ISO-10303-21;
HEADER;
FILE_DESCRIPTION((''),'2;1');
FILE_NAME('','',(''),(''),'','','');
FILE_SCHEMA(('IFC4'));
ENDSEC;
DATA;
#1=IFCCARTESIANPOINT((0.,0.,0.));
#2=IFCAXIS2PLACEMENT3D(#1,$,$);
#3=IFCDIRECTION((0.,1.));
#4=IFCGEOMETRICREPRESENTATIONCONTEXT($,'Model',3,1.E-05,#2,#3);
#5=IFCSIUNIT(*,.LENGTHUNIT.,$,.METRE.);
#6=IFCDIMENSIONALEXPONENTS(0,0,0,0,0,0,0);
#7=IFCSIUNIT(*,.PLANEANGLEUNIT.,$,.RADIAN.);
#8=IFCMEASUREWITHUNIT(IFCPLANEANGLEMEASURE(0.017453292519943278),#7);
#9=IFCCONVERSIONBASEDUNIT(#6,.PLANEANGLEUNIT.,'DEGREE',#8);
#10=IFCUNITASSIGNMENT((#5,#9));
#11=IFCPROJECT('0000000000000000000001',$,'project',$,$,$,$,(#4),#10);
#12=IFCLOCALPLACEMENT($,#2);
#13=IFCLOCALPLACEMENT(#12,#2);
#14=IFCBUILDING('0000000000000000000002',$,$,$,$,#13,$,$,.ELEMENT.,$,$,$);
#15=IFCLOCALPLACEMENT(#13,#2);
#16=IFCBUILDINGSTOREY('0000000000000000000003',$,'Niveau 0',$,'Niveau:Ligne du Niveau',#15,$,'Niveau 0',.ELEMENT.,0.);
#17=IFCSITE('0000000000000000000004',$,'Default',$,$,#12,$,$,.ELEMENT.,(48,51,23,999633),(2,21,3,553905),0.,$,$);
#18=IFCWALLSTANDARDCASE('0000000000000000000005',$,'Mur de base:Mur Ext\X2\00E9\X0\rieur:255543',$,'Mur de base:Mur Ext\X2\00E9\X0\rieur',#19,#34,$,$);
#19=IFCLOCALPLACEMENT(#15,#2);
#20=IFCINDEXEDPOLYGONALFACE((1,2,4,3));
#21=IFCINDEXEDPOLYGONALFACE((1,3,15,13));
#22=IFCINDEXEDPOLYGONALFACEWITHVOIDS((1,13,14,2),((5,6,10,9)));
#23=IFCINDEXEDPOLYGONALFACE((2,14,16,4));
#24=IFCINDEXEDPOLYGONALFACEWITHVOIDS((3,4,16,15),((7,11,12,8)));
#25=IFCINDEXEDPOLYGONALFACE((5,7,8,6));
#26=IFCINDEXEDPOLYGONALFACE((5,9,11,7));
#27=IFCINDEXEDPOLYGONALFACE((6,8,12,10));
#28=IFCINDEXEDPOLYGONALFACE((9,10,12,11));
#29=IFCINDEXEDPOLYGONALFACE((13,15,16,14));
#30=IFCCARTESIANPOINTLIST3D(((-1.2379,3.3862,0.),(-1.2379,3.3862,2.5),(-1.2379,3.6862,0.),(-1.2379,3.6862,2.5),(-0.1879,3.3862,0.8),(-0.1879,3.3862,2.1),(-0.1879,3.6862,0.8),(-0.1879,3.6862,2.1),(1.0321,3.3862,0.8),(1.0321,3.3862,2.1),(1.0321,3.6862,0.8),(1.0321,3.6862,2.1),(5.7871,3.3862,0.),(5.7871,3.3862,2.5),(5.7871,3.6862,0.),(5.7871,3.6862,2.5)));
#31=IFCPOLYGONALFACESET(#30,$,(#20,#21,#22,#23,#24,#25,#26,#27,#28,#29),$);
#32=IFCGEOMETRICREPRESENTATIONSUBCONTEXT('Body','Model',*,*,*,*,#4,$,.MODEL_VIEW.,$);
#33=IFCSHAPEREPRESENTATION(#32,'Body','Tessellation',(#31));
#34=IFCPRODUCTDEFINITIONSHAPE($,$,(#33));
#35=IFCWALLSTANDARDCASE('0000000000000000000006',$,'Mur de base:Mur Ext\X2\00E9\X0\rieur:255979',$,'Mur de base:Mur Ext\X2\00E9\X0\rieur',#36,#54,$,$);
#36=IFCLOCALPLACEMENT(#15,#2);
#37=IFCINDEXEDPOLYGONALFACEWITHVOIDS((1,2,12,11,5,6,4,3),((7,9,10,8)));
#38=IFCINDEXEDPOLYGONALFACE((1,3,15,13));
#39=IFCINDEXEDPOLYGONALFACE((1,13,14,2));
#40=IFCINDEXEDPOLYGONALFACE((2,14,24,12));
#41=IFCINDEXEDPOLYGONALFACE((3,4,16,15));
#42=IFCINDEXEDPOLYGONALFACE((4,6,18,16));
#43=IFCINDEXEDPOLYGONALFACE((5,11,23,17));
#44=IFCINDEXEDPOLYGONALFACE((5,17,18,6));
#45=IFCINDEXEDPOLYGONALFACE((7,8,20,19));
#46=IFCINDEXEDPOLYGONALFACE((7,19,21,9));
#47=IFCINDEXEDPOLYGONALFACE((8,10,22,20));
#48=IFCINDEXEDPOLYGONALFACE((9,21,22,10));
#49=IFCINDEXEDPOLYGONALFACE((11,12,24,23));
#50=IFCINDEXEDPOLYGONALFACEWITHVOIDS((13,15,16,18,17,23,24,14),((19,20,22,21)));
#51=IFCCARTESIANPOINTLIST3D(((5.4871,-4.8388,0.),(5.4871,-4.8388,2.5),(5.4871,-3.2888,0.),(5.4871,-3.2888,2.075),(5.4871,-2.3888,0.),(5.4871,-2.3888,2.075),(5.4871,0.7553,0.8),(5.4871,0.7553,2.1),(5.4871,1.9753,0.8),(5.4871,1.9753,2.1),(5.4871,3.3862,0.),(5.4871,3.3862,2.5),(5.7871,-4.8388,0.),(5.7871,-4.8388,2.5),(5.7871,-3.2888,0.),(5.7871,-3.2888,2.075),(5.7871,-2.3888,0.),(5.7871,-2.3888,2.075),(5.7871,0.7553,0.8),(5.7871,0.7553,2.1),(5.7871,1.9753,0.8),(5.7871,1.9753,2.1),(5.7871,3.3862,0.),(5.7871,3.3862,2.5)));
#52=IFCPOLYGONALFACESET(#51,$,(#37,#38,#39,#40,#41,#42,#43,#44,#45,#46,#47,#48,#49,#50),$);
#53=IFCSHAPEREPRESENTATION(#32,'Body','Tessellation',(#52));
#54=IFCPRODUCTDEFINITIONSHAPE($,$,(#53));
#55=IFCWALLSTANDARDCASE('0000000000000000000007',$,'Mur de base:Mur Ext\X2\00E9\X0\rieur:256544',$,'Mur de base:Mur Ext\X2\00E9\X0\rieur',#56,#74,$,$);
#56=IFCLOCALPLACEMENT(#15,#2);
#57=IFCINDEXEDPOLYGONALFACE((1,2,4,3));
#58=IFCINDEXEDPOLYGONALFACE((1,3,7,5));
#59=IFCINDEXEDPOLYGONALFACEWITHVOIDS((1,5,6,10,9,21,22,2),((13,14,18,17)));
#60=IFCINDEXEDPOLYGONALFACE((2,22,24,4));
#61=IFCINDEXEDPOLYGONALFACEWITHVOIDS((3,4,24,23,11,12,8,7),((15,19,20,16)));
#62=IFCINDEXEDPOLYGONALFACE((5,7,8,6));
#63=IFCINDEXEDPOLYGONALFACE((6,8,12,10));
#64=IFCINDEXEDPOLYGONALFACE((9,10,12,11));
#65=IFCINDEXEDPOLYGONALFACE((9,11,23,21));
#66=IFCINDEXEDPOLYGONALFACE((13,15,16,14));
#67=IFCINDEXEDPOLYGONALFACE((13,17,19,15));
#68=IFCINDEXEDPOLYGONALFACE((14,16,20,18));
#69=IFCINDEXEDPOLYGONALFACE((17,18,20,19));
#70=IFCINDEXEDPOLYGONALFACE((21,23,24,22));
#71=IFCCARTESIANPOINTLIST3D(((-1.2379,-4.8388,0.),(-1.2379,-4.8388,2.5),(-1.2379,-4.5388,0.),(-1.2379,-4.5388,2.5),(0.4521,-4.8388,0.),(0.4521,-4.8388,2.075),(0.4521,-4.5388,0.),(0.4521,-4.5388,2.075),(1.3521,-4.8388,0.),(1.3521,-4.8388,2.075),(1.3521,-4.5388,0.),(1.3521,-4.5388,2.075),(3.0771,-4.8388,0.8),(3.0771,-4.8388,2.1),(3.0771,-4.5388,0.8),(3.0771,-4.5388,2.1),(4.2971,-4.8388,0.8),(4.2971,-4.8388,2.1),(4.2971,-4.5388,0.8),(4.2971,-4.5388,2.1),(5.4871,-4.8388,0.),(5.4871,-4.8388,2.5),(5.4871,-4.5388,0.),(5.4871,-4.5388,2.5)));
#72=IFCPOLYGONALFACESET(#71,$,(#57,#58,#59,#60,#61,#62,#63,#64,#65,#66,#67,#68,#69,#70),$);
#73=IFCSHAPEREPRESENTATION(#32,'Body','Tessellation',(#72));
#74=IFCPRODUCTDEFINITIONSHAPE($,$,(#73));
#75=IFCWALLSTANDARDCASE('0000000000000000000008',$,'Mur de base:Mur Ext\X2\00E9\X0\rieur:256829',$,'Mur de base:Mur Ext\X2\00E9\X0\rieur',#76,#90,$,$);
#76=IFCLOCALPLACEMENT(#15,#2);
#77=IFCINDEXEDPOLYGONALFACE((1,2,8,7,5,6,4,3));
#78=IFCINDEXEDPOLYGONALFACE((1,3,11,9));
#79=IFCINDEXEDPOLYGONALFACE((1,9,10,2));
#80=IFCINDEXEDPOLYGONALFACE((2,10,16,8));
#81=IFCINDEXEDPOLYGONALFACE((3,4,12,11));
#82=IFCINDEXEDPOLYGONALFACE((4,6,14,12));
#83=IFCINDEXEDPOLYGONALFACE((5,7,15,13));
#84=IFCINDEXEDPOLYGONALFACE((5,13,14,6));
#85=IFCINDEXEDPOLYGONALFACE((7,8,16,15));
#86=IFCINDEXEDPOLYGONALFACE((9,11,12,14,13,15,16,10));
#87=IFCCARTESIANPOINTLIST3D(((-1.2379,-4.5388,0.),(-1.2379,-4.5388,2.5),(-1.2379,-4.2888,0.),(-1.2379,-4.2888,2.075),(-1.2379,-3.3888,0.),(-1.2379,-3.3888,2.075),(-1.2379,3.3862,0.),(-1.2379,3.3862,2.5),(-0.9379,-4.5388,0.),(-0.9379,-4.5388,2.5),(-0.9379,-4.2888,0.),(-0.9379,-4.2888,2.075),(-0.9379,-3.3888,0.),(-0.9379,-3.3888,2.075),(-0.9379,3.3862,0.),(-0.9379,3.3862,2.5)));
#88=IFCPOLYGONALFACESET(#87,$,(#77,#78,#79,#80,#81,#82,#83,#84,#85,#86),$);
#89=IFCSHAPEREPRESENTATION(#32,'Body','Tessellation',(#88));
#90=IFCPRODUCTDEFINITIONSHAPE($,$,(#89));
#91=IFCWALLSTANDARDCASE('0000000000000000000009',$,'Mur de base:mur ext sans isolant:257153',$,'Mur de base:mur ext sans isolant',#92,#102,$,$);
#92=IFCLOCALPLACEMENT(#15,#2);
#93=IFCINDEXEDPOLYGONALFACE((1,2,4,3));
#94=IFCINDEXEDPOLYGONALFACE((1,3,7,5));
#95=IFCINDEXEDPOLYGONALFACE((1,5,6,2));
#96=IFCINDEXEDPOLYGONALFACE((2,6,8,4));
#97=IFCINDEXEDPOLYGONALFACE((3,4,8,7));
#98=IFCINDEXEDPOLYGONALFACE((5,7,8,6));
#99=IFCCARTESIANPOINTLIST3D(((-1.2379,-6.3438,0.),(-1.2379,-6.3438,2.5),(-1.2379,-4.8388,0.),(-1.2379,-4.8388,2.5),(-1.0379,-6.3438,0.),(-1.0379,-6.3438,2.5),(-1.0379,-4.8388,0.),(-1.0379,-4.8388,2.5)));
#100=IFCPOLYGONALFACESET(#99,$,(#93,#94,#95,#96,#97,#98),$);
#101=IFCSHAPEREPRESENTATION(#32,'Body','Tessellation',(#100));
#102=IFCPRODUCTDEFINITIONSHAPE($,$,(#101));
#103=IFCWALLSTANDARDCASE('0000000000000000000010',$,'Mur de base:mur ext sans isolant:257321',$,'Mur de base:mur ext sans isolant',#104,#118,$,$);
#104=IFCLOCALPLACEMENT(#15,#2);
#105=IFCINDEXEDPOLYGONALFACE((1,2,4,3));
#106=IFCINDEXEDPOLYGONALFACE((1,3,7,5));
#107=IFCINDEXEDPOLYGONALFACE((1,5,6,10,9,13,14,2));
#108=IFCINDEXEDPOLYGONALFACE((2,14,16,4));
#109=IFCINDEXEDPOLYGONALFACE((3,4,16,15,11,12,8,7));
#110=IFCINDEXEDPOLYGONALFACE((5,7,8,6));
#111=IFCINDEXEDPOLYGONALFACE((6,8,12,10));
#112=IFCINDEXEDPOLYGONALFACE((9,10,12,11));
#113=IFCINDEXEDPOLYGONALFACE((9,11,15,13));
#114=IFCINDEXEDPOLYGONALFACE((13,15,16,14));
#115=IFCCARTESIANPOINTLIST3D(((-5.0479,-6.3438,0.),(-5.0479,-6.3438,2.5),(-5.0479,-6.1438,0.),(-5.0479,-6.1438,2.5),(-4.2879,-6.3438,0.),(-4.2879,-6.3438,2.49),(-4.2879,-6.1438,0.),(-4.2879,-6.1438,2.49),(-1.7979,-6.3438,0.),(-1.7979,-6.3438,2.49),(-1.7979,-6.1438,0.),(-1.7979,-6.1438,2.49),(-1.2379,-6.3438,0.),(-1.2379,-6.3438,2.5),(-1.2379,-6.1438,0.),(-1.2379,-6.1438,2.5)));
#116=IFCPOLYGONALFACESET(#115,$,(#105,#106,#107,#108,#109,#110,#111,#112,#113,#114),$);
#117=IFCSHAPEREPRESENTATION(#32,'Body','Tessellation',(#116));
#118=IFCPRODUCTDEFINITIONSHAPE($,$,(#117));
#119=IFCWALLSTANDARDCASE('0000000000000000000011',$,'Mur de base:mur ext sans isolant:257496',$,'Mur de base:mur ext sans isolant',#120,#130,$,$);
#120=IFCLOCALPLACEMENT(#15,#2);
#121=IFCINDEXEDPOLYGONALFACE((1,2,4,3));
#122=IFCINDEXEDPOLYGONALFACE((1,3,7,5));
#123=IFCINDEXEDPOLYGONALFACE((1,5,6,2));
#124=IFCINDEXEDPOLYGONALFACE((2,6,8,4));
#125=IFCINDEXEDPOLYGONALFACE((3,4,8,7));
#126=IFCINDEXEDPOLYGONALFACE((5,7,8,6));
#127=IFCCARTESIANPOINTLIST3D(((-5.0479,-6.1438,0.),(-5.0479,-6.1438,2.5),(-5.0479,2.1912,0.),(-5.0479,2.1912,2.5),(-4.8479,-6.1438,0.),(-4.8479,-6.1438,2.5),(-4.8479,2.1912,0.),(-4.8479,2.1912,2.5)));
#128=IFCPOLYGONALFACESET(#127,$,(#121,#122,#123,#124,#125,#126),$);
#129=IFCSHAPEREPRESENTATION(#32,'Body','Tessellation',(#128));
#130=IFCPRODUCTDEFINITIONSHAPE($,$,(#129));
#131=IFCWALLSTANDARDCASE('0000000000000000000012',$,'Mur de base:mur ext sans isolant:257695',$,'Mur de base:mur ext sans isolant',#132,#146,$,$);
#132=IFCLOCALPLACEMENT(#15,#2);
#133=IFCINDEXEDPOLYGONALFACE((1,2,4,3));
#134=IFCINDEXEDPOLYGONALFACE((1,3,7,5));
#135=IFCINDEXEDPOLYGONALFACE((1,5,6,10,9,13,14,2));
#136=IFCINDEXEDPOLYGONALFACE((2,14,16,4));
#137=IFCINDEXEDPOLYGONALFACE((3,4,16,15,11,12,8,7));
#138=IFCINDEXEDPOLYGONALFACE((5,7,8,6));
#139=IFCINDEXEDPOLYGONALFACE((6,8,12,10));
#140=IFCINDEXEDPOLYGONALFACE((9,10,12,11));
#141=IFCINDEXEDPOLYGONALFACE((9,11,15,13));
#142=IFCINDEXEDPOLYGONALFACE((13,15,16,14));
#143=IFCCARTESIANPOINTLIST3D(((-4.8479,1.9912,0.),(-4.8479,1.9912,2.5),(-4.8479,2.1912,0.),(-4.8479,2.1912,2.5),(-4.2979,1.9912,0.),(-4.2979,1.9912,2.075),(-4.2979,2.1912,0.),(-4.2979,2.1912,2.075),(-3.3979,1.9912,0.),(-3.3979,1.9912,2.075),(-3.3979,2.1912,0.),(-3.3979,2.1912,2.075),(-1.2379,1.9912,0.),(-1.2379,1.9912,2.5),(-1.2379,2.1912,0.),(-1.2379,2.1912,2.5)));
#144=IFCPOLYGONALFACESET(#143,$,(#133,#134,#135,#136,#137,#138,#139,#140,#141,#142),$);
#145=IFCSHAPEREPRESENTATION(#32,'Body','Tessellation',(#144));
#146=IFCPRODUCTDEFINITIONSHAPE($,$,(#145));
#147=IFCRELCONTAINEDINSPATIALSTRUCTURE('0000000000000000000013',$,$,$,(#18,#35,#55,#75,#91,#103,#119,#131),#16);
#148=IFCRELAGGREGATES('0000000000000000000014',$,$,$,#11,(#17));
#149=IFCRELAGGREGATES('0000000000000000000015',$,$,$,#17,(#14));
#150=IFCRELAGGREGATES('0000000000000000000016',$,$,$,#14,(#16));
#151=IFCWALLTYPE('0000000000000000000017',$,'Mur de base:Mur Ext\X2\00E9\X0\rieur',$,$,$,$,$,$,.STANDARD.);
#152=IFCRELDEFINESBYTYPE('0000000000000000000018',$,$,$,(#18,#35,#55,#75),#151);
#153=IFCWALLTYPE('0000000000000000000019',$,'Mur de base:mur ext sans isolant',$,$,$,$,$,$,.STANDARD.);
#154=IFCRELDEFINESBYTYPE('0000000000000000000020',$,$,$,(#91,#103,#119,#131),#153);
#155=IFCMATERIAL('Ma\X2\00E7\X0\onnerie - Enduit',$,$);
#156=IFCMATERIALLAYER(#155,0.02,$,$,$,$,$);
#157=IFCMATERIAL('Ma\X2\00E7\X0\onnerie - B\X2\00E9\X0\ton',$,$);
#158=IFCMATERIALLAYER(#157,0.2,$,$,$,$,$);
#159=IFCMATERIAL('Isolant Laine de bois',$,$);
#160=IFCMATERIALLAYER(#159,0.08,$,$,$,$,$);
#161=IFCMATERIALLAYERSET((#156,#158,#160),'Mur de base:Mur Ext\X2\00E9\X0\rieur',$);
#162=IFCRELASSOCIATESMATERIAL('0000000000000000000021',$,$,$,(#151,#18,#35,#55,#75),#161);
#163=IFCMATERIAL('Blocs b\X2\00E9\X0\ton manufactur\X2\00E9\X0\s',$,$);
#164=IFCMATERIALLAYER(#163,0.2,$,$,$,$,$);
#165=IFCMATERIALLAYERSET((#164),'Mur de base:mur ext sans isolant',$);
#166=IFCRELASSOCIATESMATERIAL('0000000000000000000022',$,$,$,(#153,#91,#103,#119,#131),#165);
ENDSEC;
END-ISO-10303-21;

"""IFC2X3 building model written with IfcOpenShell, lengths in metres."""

from ifc_helpers import new_model, entity, si_unit, converted_unit, direction, frame, frame_2d, origin, place, context, subcontext, project, spatial, rectangle, extrude, material, layer, layer_set, layer_usage, type_object, element, save


model = new_model("IFC2X3")

# Units and contexts
model_context = context("Model", 3, precision=1e-05, world=origin(), true_north=direction((0.0, 1.0)))
body_context = subcontext(model_context, "Body", "Model", "MODEL_VIEW")
ifc_project = project(units=[si_unit("LENGTHUNIT", "METRE"), converted_unit("PLANEANGLEUNIT", "DEGREE", entity("IfcPlaneAngleMeasure", 0.017453292519943278), si_unit("PLANEANGLEUNIT", "RADIAN"), dimensions=[0, 0, 0, 0, 0, 0, 0])], contexts=[model_context])

# Site, building, storey
site_placement = place(None, origin())
site = spatial("IfcSite", under=ifc_project, at=site_placement, Name="Default", CompositionType="ELEMENT", RefLatitude=(48, 51, 23, 999633), RefLongitude=(2, 21, 3, 553905), RefElevation=0.0)
building_placement = place(site_placement, origin())
building = spatial("IfcBuilding", under=site, at=building_placement, CompositionType="ELEMENT")
storey_placement = place(building_placement, origin())
storey = spatial("IfcBuildingStorey", under=building, at=storey_placement, Name="Niveau 0", ObjectType="Niveau:Ligne du Niveau", LongName="Niveau 0", CompositionType="ELEMENT", Elevation=0.0)

# Wall, opening
ifc_material_1 = material(Name="Maçonnerie - Enduit")
ifc_layer_1 = layer(ifc_material_1, 0.02)
ifc_material_2 = material(Name="Maçonnerie - Béton")
ifc_layer_2 = layer(ifc_material_2, 0.2)
ifc_material_3 = material(Name="Isolant Laine de bois")
ifc_layer_3 = layer(ifc_material_3, 0.08)
ifc_layer_set_1 = layer_set([ifc_layer_1, ifc_layer_2, ifc_layer_3], Name="Mur de base:Mur Extérieur")
ifc_layer_usage_1 = layer_usage(ifc_layer_set_1, "AXIS2", "NEGATIVE", 0.15)
wall_type_1 = type_object("IfcWallType", Name="Mur de base:Mur Extérieur", PredefinedType="STANDARD", material=ifc_layer_set_1)
wall_1_placement = place(storey_placement, frame((-1.2379, 3.5362, 0.0)))
wall_1 = element("IfcWallStandardCase", 1, at=wall_1_placement, inside=storey, type_object=wall_type_1, material=ifc_layer_usage_1, Name="Mur de base:Mur Extérieur:255543", ObjectType="Mur de base:Mur Extérieur", context=body_context, shape_type="SweptSolid", body=[
    extrude(rectangle(XDim=7.025, YDim=0.3, at=frame_2d((3.5125, 0.0), x_axis=(-1.0, 0.0))), origin(), (0.0, 0.0, 1.0), 2.5),
])
opening_1_placement = place(wall_1_placement, frame((1.05, -0.15, 0.8)))
element("IfcOpeningElement", 2, at=opening_1_placement, cuts=wall_1, ObjectType="Opening", context=body_context, shape_type="SweptSolid", body=[
    extrude(rectangle(XDim=1.3, YDim=1.22, at=frame_2d((0.65, 0.61), x_axis=(1.0, 0.0))), frame((0.0, 0.0, 0.0), z_axis=(0.0, 1.0, 0.0), x_axis=(0.0, 0.0, 1.0)), (0.0, 0.0, 1.0), 0.3),
])

# Walls, openings
ifc_layer_usage_2 = layer_usage(ifc_layer_set_1, "AXIS2", "NEGATIVE", 0.15)
wall_2_placement = place(storey_placement, frame((5.6371, 3.3862, 0.0), z_axis=(0.0, 0.0, 1.0), x_axis=(0.0, -1.0, 0.0)))
wall_2 = element("IfcWallStandardCase", 3, at=wall_2_placement, inside=storey, type_object=wall_type_1, material=ifc_layer_usage_2, Name="Mur de base:Mur Extérieur:255979", ObjectType="Mur de base:Mur Extérieur", context=body_context, shape_type="SweptSolid", body=[
    extrude(rectangle(XDim=8.225, YDim=0.3, at=frame_2d((4.1125, 0.0), x_axis=(-1.0, 0.0))), origin(), (0.0, 0.0, 1.0), 2.5),
])
opening_2_placement = place(wall_2_placement, frame((5.775, -0.15, 0.0)))
element("IfcOpeningElement", 4, at=opening_2_placement, cuts=wall_2, ObjectType="Opening", context=body_context, shape_type="SweptSolid", body=[
    extrude(rectangle(XDim=2.075, YDim=0.9, at=frame_2d((1.0375, 0.45), x_axis=(1.0, 0.0))), frame((0.0, 0.0, 0.0), z_axis=(0.0, 1.0, 0.0), x_axis=(0.0, 0.0, 1.0)), (0.0, 0.0, 1.0), 0.3),
])
opening_3_placement = place(wall_2_placement, frame((1.4109, -0.15, 0.8)))
element("IfcOpeningElement", 5, at=opening_3_placement, cuts=wall_2, ObjectType="Opening", context=body_context, shape_type="SweptSolid", body=[
    extrude(rectangle(XDim=1.3, YDim=1.22, at=frame_2d((0.65, 0.61), x_axis=(1.0, 0.0))), frame((0.0, 0.0, 0.0), z_axis=(0.0, 1.0, 0.0), x_axis=(0.0, 0.0, 1.0)), (0.0, 0.0, 1.0), 0.3),
])
ifc_layer_usage_3 = layer_usage(ifc_layer_set_1, "AXIS2", "NEGATIVE", 0.15)
wall_3_placement = place(storey_placement, frame((5.4871, -4.6888, 0.0), z_axis=(0.0, 0.0, 1.0), x_axis=(-1.0, 0.0, 0.0)))
wall_3 = element("IfcWallStandardCase", 6, at=wall_3_placement, inside=storey, type_object=wall_type_1, material=ifc_layer_usage_3, Name="Mur de base:Mur Extérieur:256544", ObjectType="Mur de base:Mur Extérieur", context=body_context, shape_type="SweptSolid", body=[
    extrude(rectangle(XDim=6.725, YDim=0.3, at=frame_2d((3.3625, 0.0), x_axis=(-1.0, 0.0))), origin(), (0.0, 0.0, 1.0), 2.5),
])
opening_4_placement = place(wall_3_placement, frame((5.035, 0.15, 0.0)))
element("IfcOpeningElement", 7, at=opening_4_placement, cuts=wall_3, ObjectType="Opening", context=body_context, shape_type="SweptSolid", body=[
    extrude(rectangle(XDim=2.075, YDim=0.9, at=frame_2d((1.0375, 0.45), x_axis=(1.0, 0.0))), frame((0.0, 0.0, 0.0), z_axis=(0.0, -1.0, 0.0), x_axis=(0.0, 0.0, 1.0)), (0.0, 0.0, 1.0), 0.3),
])
opening_5_placement = place(wall_3_placement, frame((1.19, -0.15, 0.8)))
element("IfcOpeningElement", 8, at=opening_5_placement, cuts=wall_3, ObjectType="Opening", context=body_context, shape_type="SweptSolid", body=[
    extrude(rectangle(XDim=1.3, YDim=1.22, at=frame_2d((0.65, 0.61), x_axis=(1.0, 0.0))), frame((0.0, 0.0, 0.0), z_axis=(0.0, 1.0, 0.0), x_axis=(0.0, 0.0, 1.0)), (0.0, 0.0, 1.0), 0.3),
])

# Wall, opening
ifc_layer_usage_4 = layer_usage(ifc_layer_set_1, "AXIS2", "POSITIVE", -0.15)
wall_4_placement = place(storey_placement, frame((-1.0879, 3.3862, 0.0), z_axis=(0.0, 0.0, 1.0), x_axis=(0.0, -1.0, 0.0)))
wall_4 = element("IfcWallStandardCase", 9, at=wall_4_placement, inside=storey, type_object=wall_type_1, material=ifc_layer_usage_4, Name="Mur de base:Mur Extérieur:256829", ObjectType="Mur de base:Mur Extérieur", context=body_context, shape_type="SweptSolid", body=[
    extrude(rectangle(XDim=7.925, YDim=0.3, at=frame_2d((3.9625, 0.0), x_axis=(1.0, 0.0))), origin(), (0.0, 0.0, 1.0), 2.5),
])
opening_6_placement = place(wall_4_placement, frame((6.775, -0.15, 0.0)))
element("IfcOpeningElement", 10, at=opening_6_placement, cuts=wall_4, ObjectType="Opening", context=body_context, shape_type="SweptSolid", body=[
    extrude(rectangle(XDim=2.075, YDim=0.9, at=frame_2d((1.0375, 0.45), x_axis=(1.0, 0.0))), frame((0.0, 0.0, 0.0), z_axis=(0.0, 1.0, 0.0), x_axis=(0.0, 0.0, 1.0)), (0.0, 0.0, 1.0), 0.3),
])

# Wall
ifc_material_4 = material(Name="Blocs béton manufacturés")
ifc_layer_4 = layer(ifc_material_4, 0.2)
ifc_layer_set_2 = layer_set([ifc_layer_4], Name="Mur de base:mur ext sans isolant")
ifc_layer_usage_5 = layer_usage(ifc_layer_set_2, "AXIS2", "POSITIVE", -0.1)
wall_type_2 = type_object("IfcWallType", Name="Mur de base:mur ext sans isolant", PredefinedType="STANDARD", material=ifc_layer_set_2)
wall_5_placement = place(storey_placement, frame((-1.1379, -4.8388, 0.0), z_axis=(0.0, 0.0, 1.0), x_axis=(0.0, -1.0, 0.0)))
element("IfcWallStandardCase", 11, at=wall_5_placement, inside=storey, type_object=wall_type_2, material=ifc_layer_usage_5, Name="Mur de base:mur ext sans isolant:257153", ObjectType="Mur de base:mur ext sans isolant", context=body_context, shape_type="SweptSolid", body=[
    extrude(rectangle(XDim=1.505, YDim=0.2, at=frame_2d((0.7525, 0.0), x_axis=(-1.0, 0.0))), origin(), (0.0, 0.0, 1.0), 2.5),
])

# Wall, opening
ifc_layer_usage_6 = layer_usage(ifc_layer_set_2, "AXIS2", "NEGATIVE", 0.1)
wall_6_placement = place(storey_placement, frame((-1.2379, -6.2438, 0.0), z_axis=(0.0, 0.0, 1.0), x_axis=(-1.0, 0.0, 0.0)))
wall_6 = element("IfcWallStandardCase", 12, at=wall_6_placement, inside=storey, type_object=wall_type_2, material=ifc_layer_usage_6, Name="Mur de base:mur ext sans isolant:257321", ObjectType="Mur de base:mur ext sans isolant", context=body_context, shape_type="SweptSolid", body=[
    extrude(rectangle(XDim=3.81, YDim=0.2, at=frame_2d((1.905, 0.0), x_axis=(-1.0, 0.0))), origin(), (0.0, 0.0, 1.0), 2.5),
])
opening_7_placement = place(wall_6_placement, frame((0.56, -0.1, 0.0)))
element("IfcOpeningElement", 13, at=opening_7_placement, cuts=wall_6, ObjectType="Opening", context=body_context, shape_type="SweptSolid", body=[
    extrude(rectangle(XDim=2.49, YDim=2.49, at=frame_2d((1.245, 1.245), x_axis=(-1.0, 0.0))), frame((0.0, 0.0, 0.0), z_axis=(0.0, 1.0, 0.0), x_axis=(0.0, 0.0, 1.0)), (0.0, 0.0, 1.0), 0.2),
])

# Wall
ifc_layer_usage_7 = layer_usage(ifc_layer_set_2, "AXIS2", "NEGATIVE", 0.1)
wall_7_placement = place(storey_placement, frame((-4.9479, -6.1438, 0.0), z_axis=(0.0, 0.0, 1.0), x_axis=(0.0, 1.0, 0.0)))
element("IfcWallStandardCase", 14, at=wall_7_placement, inside=storey, type_object=wall_type_2, material=ifc_layer_usage_7, Name="Mur de base:mur ext sans isolant:257496", ObjectType="Mur de base:mur ext sans isolant", context=body_context, shape_type="SweptSolid", body=[
    extrude(rectangle(XDim=8.335, YDim=0.2, at=frame_2d((4.1675, 0.0), x_axis=(-1.0, 0.0))), origin(), (0.0, 0.0, 1.0), 2.5),
])

# Wall, opening
ifc_layer_usage_8 = layer_usage(ifc_layer_set_2, "AXIS2", "NEGATIVE", 0.1)
wall_8_placement = place(storey_placement, frame((-4.8479, 2.0912, 0.0)))
wall_8 = element("IfcWallStandardCase", 15, at=wall_8_placement, inside=storey, type_object=wall_type_2, material=ifc_layer_usage_8, Name="Mur de base:mur ext sans isolant:257695", ObjectType="Mur de base:mur ext sans isolant", context=body_context, shape_type="SweptSolid", body=[
    extrude(rectangle(XDim=3.61, YDim=0.2, at=frame_2d((1.805, 0.0), x_axis=(-1.0, 0.0))), origin(), (0.0, 0.0, 1.0), 2.5),
])
opening_8_placement = place(wall_8_placement, frame((1.45, 0.1, 0.0)))
element("IfcOpeningElement", 16, at=opening_8_placement, cuts=wall_8, ObjectType="Opening", context=body_context, shape_type="SweptSolid", body=[
    extrude(rectangle(XDim=2.075, YDim=0.9, at=frame_2d((1.0375, 0.45), x_axis=(1.0, 0.0))), frame((0.0, 0.0, 0.0), z_axis=(0.0, -1.0, 0.0), x_axis=(0.0, 0.0, 1.0)), (0.0, 0.0, 1.0), 0.2),
])

save(model, "model.ifc")
